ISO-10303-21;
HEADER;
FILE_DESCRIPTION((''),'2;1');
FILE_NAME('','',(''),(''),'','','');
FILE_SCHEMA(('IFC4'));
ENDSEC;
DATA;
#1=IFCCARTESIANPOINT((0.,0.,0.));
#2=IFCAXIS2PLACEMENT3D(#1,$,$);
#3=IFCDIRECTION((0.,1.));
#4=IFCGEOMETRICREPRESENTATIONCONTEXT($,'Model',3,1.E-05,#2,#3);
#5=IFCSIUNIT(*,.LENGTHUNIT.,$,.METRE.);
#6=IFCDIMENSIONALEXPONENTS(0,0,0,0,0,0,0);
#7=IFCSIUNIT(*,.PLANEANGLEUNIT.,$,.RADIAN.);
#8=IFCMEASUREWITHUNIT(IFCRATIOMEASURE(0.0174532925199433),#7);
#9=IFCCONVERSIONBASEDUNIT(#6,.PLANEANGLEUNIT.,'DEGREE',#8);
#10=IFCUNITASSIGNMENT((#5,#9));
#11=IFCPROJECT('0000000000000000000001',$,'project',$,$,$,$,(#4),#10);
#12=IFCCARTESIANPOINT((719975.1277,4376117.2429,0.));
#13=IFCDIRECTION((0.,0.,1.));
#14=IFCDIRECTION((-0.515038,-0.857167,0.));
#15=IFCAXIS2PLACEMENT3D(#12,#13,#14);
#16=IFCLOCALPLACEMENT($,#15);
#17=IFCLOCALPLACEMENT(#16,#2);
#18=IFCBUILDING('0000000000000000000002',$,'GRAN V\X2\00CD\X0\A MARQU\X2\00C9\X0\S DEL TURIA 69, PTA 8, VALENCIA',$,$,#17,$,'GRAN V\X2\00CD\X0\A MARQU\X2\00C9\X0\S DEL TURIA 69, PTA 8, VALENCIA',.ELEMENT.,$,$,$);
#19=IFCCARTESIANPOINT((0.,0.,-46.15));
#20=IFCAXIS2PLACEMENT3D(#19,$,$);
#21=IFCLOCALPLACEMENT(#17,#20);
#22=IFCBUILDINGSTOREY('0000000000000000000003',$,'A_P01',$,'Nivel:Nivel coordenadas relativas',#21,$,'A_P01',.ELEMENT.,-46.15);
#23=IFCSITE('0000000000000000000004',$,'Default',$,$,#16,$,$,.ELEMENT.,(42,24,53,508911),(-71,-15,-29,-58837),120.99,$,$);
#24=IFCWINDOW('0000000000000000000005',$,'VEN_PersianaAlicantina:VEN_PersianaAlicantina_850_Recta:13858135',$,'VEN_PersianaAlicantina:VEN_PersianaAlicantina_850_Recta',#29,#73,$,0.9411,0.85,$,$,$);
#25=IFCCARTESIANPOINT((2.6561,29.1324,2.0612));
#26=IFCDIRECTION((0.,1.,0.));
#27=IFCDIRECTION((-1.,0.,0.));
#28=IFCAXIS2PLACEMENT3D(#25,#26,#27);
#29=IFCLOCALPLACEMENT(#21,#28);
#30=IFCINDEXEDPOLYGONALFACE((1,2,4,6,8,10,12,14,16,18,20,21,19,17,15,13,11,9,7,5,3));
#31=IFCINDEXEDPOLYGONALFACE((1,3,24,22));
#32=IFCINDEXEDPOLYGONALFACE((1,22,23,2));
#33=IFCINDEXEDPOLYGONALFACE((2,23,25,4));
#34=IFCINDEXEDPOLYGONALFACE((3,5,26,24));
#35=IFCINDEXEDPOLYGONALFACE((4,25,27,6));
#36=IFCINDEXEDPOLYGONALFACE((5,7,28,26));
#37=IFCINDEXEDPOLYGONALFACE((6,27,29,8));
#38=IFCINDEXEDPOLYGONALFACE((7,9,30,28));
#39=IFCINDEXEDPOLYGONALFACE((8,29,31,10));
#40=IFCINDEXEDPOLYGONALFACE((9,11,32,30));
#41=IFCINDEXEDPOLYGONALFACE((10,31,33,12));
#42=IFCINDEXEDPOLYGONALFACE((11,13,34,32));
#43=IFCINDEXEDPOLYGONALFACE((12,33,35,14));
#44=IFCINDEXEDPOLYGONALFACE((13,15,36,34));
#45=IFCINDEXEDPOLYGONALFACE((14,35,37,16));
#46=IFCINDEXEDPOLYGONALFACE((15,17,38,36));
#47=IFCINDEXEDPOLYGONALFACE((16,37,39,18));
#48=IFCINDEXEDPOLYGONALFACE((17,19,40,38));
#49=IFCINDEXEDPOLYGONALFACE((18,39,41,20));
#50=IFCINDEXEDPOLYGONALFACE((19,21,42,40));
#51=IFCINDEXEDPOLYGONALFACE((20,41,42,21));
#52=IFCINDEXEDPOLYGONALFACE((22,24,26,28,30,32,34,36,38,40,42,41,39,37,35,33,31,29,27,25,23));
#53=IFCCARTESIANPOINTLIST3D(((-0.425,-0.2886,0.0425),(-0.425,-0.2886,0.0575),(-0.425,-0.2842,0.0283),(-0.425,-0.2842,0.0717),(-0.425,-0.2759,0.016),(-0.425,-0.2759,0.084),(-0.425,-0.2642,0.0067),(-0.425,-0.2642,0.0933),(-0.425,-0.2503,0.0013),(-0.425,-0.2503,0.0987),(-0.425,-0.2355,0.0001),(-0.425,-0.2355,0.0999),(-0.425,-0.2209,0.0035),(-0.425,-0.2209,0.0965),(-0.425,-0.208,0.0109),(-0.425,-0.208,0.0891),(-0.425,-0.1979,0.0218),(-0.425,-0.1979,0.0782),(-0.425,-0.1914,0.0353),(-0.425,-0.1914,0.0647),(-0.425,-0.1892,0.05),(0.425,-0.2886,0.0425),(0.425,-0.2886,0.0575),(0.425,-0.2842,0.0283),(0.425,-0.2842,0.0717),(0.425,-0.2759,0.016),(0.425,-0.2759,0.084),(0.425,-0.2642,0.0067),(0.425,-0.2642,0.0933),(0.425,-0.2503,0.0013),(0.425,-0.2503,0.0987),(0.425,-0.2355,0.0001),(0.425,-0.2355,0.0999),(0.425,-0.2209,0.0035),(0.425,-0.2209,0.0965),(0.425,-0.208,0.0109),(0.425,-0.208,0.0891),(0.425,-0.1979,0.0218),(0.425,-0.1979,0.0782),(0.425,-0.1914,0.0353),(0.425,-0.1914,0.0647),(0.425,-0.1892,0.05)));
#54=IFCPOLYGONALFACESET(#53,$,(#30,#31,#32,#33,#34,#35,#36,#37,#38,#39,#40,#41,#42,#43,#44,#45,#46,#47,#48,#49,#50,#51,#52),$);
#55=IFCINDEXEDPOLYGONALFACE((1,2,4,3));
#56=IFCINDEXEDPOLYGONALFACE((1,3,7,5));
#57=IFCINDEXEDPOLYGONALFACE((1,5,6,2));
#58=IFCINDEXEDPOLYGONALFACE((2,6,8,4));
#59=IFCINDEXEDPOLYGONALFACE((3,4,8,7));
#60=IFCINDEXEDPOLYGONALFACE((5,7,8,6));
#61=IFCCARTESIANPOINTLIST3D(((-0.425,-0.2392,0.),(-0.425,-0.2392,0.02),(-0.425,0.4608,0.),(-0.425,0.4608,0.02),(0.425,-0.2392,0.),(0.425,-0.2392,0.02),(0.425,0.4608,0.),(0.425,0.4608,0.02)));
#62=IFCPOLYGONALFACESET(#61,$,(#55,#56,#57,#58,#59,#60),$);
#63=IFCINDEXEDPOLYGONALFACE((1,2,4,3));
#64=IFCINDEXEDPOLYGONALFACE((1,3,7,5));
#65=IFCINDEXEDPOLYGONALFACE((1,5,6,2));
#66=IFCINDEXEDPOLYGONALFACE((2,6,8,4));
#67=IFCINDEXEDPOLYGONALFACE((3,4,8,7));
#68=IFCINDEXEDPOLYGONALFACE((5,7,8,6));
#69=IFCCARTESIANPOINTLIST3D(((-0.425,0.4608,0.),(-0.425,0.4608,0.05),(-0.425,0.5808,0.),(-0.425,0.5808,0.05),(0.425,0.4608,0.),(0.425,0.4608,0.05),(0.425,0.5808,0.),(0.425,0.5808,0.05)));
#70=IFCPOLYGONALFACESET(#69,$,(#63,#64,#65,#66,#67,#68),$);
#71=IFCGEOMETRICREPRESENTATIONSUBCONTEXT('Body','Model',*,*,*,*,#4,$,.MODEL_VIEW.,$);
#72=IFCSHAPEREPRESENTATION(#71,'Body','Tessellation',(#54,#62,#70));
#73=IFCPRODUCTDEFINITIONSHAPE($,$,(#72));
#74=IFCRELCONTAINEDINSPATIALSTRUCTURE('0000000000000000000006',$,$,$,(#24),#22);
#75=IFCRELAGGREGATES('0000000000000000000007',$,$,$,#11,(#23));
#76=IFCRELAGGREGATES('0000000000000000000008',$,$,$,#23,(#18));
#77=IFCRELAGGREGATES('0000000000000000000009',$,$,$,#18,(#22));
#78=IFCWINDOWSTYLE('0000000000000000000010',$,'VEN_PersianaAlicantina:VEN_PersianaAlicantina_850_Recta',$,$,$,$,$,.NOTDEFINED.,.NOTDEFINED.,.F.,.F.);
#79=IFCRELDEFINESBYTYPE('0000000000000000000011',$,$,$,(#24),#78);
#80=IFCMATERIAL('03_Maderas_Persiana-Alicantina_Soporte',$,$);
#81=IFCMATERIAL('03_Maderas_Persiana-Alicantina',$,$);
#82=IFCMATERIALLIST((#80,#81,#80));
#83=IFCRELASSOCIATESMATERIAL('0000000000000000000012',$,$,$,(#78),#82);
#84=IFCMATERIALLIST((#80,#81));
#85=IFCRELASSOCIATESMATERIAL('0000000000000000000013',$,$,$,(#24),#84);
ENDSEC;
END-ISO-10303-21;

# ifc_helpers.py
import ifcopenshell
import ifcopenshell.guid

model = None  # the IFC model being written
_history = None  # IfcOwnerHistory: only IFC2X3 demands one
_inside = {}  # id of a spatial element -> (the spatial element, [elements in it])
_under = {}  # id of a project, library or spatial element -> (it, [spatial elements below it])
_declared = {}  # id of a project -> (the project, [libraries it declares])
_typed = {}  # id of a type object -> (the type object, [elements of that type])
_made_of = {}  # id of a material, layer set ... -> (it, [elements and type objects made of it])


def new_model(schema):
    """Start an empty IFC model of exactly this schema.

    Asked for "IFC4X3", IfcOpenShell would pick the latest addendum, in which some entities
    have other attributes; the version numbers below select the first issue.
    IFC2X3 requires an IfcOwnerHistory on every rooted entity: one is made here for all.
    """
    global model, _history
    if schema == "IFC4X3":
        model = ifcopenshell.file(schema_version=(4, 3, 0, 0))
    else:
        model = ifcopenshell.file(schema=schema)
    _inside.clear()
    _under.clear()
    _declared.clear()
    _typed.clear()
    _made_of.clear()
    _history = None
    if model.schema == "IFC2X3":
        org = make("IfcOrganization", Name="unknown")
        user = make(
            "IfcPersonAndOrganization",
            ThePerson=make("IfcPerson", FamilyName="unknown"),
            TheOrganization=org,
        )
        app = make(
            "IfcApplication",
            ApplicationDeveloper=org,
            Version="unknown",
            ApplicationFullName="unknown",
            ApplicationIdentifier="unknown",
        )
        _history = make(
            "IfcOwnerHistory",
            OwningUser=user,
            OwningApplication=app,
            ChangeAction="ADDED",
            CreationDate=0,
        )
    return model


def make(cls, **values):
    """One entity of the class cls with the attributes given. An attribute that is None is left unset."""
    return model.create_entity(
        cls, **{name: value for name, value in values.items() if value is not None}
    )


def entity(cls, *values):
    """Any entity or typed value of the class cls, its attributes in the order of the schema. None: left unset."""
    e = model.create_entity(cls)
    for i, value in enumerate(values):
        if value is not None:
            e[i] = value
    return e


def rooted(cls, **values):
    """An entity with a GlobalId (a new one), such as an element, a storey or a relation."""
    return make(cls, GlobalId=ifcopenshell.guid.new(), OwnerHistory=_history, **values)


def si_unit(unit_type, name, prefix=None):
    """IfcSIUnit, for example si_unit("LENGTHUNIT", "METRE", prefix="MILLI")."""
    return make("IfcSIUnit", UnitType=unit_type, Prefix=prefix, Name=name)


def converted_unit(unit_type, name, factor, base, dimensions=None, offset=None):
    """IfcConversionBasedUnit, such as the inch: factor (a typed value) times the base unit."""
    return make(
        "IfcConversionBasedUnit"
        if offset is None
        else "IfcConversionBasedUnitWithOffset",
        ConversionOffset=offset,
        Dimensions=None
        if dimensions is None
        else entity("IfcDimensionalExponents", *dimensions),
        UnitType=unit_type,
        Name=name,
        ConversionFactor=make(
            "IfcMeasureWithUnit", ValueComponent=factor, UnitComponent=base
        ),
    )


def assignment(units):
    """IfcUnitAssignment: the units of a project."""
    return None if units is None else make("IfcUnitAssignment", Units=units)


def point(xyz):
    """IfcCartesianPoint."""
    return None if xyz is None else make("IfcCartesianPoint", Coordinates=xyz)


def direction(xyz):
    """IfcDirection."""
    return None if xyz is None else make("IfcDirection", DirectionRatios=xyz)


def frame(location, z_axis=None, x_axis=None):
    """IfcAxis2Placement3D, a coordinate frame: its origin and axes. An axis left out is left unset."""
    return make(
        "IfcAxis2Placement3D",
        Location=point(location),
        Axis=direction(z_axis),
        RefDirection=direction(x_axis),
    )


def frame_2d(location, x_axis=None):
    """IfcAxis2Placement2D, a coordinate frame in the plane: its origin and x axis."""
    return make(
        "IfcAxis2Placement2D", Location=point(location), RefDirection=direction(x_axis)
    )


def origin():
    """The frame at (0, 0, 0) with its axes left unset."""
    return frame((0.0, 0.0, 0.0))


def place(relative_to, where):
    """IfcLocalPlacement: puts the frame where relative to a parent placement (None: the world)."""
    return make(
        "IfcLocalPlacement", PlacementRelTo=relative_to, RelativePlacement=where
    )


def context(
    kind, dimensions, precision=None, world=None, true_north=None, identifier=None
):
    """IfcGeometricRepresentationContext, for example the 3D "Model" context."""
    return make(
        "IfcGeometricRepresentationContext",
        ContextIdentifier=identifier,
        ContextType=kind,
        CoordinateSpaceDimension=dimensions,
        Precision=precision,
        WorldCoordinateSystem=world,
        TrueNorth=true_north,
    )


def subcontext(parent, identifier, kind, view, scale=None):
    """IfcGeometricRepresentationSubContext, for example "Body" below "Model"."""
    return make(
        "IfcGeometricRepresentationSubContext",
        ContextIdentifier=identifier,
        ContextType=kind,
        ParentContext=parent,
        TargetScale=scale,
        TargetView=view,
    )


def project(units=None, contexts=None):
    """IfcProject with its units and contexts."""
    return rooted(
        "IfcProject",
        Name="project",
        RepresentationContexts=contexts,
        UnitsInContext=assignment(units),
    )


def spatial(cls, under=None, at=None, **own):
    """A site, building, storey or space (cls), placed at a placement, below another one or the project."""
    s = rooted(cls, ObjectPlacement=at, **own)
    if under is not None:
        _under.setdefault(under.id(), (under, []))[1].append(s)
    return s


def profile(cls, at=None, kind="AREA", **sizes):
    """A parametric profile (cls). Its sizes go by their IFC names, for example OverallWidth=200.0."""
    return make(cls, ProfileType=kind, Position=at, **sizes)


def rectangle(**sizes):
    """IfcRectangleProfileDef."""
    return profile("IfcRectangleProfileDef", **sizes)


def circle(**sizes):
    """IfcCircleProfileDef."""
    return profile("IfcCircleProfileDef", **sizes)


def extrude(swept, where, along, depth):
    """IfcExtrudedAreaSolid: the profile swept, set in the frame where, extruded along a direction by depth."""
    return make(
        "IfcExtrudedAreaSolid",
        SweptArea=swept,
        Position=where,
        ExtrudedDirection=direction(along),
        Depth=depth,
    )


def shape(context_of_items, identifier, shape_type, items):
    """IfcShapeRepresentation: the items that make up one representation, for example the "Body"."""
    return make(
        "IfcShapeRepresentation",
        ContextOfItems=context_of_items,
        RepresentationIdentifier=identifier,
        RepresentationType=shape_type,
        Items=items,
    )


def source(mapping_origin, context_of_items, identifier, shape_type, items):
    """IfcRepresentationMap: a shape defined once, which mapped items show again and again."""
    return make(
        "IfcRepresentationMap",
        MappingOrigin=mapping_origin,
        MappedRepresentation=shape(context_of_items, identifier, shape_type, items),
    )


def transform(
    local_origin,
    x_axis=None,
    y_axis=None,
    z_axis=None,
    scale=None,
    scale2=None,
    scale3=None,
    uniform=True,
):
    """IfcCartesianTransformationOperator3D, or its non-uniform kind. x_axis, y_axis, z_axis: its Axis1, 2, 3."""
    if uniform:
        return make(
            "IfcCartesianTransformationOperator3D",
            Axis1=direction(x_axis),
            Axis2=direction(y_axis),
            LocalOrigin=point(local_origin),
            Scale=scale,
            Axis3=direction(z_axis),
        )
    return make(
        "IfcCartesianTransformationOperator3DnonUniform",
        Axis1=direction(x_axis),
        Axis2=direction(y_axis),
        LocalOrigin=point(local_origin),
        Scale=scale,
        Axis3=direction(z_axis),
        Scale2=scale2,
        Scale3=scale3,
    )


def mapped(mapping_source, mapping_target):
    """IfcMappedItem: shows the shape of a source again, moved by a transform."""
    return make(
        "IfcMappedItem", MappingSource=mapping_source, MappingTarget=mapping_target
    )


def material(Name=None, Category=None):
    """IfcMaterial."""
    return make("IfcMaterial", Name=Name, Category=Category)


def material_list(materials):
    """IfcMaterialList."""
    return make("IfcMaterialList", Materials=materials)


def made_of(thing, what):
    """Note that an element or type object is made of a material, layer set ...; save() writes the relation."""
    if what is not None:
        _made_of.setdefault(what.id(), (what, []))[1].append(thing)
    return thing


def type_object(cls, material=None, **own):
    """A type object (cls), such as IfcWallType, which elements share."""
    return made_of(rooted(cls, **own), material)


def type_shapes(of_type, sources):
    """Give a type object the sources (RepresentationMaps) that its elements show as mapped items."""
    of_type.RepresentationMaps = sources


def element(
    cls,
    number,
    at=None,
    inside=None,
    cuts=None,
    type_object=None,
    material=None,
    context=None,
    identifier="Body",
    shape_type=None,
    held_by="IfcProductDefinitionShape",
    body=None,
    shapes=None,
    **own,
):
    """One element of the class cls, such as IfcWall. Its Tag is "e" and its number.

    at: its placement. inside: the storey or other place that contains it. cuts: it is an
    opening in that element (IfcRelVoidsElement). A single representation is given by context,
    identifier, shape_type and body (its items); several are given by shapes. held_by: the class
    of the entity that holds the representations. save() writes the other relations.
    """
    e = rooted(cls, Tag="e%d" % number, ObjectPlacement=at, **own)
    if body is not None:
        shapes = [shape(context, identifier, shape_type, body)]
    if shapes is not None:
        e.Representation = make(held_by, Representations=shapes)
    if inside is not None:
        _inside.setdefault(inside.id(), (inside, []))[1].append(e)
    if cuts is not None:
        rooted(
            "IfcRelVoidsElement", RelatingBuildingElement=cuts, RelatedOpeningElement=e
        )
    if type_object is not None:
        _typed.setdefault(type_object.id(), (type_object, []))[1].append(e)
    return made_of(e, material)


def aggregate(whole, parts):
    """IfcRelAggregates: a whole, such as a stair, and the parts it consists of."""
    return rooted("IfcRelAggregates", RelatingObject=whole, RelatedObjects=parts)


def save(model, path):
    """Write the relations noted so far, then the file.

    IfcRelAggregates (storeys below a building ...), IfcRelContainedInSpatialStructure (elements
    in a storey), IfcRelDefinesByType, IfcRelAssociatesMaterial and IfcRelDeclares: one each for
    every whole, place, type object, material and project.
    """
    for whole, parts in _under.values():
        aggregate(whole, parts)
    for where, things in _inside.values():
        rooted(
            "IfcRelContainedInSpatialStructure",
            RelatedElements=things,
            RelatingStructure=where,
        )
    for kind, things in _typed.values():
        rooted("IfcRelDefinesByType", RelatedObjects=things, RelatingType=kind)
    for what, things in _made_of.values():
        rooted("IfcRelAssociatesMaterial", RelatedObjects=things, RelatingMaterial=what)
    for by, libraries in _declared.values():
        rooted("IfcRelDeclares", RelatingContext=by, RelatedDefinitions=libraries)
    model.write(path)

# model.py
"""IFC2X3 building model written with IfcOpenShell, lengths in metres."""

from ifc_helpers import new_model, entity, si_unit, converted_unit, direction, frame, frame_2d, origin, place, context, subcontext, project, spatial, rectangle, circle, extrude, source, transform, mapped, material, material_list, type_object, type_shapes, element, save


model = new_model("IFC2X3")

# Units and contexts
model_context = context("Model", 3, precision=1e-05, world=origin(), true_north=direction((0.0, 1.0)))
body_context = subcontext(model_context, "Body", "Model", "MODEL_VIEW")
ifc_project = project(units=[si_unit("LENGTHUNIT", "METRE"), converted_unit("PLANEANGLEUNIT", "DEGREE", entity("IfcRatioMeasure", 0.0174532925199433), si_unit("PLANEANGLEUNIT", "RADIAN"), dimensions=[0, 0, 0, 0, 0, 0, 0])], contexts=[model_context])

# Site, building, storey
site_placement = place(None, frame((719975.1277, 4376117.2429, 0.0), z_axis=(0.0, 0.0, 1.0), x_axis=(-0.515038, -0.857167, 0.0)))
site = spatial("IfcSite", under=ifc_project, at=site_placement, Name="Default", CompositionType="ELEMENT", RefLatitude=(42, 24, 53, 508911), RefLongitude=(-71, -15, -29, -58837), RefElevation=120.99)
building_placement = place(site_placement, origin())
building = spatial("IfcBuilding", under=site, at=building_placement, Name="GRAN VÍA MARQUÉS DEL TURIA 69, PTA 8, VALENCIA", LongName="GRAN VÍA MARQUÉS DEL TURIA 69, PTA 8, VALENCIA", CompositionType="ELEMENT")
storey_placement = place(building_placement, frame((0.0, 0.0, -46.15)))
storey = spatial("IfcBuildingStorey", under=building, at=storey_placement, Name="A_P01", ObjectType="Nivel:Nivel coordenadas relativas", LongName="A_P01", CompositionType="ELEMENT", Elevation=-46.15)

# Window
ifc_material_1 = material(Name="03_Maderas_Persiana-Alicantina_Soporte")
ifc_material_2 = material(Name="03_Maderas_Persiana-Alicantina")
ifc_material_list_1 = material_list([ifc_material_1, ifc_material_2])
ifc_material_list_2 = material_list([ifc_material_1, ifc_material_2, ifc_material_1])
window_style_1 = type_object("IfcWindowStyle", Name="VEN_PersianaAlicantina:VEN_PersianaAlicantina_850_Recta", ConstructionType="NOTDEFINED", OperationType="NOTDEFINED", ParameterTakesPrecedence=False, Sizeable=False, material=ifc_material_list_2)
shared_shape_1 = source(origin(), body_context, "Body", "SweptSolid", [
    extrude(circle(Radius=0.05, at=frame_2d((0.0, 0.0), x_axis=(1.0, 0.0))), frame((-0.425, -0.2392, 0.05), z_axis=(1.0, 0.0, 0.0), x_axis=(0.0, 1.0, 0.0)), (0.0, 0.0, 1.0), 0.85),
    extrude(rectangle(XDim=0.85, YDim=0.7, at=frame_2d((0.0, 0.0), x_axis=(1.0, 0.0))), frame((0.0, 0.1108, 0.0), z_axis=(0.0, 0.0, 1.0), x_axis=(-1.0, 0.0, 0.0)), (0.0, 0.0, 1.0), 0.02),
    extrude(rectangle(XDim=0.85, YDim=0.12, at=frame_2d((0.0, 0.0), x_axis=(1.0, 0.0))), frame((0.0, 0.5208, 0.0), z_axis=(0.0, 0.0, 1.0), x_axis=(-1.0, 0.0, 0.0)), (0.0, 0.0, 1.0), 0.05),
])
type_shapes(window_style_1, [shared_shape_1])
window_1_placement = place(storey_placement, frame((2.6561, 29.1324, 2.0612), z_axis=(0.0, 1.0, 0.0), x_axis=(-1.0, 0.0, 0.0)))
element("IfcWindow", 1, at=window_1_placement, inside=storey, type_object=window_style_1, material=ifc_material_list_1, Name="VEN_PersianaAlicantina:VEN_PersianaAlicantina_850_Recta:13858135", ObjectType="VEN_PersianaAlicantina:VEN_PersianaAlicantina_850_Recta", OverallHeight=0.9411, OverallWidth=0.85, context=body_context, shape_type="MappedRepresentation", body=[
    mapped(shared_shape_1, transform((0.0, 0.0, 0.0), scale=1.0)),
])

save(model, "model.ifc")
